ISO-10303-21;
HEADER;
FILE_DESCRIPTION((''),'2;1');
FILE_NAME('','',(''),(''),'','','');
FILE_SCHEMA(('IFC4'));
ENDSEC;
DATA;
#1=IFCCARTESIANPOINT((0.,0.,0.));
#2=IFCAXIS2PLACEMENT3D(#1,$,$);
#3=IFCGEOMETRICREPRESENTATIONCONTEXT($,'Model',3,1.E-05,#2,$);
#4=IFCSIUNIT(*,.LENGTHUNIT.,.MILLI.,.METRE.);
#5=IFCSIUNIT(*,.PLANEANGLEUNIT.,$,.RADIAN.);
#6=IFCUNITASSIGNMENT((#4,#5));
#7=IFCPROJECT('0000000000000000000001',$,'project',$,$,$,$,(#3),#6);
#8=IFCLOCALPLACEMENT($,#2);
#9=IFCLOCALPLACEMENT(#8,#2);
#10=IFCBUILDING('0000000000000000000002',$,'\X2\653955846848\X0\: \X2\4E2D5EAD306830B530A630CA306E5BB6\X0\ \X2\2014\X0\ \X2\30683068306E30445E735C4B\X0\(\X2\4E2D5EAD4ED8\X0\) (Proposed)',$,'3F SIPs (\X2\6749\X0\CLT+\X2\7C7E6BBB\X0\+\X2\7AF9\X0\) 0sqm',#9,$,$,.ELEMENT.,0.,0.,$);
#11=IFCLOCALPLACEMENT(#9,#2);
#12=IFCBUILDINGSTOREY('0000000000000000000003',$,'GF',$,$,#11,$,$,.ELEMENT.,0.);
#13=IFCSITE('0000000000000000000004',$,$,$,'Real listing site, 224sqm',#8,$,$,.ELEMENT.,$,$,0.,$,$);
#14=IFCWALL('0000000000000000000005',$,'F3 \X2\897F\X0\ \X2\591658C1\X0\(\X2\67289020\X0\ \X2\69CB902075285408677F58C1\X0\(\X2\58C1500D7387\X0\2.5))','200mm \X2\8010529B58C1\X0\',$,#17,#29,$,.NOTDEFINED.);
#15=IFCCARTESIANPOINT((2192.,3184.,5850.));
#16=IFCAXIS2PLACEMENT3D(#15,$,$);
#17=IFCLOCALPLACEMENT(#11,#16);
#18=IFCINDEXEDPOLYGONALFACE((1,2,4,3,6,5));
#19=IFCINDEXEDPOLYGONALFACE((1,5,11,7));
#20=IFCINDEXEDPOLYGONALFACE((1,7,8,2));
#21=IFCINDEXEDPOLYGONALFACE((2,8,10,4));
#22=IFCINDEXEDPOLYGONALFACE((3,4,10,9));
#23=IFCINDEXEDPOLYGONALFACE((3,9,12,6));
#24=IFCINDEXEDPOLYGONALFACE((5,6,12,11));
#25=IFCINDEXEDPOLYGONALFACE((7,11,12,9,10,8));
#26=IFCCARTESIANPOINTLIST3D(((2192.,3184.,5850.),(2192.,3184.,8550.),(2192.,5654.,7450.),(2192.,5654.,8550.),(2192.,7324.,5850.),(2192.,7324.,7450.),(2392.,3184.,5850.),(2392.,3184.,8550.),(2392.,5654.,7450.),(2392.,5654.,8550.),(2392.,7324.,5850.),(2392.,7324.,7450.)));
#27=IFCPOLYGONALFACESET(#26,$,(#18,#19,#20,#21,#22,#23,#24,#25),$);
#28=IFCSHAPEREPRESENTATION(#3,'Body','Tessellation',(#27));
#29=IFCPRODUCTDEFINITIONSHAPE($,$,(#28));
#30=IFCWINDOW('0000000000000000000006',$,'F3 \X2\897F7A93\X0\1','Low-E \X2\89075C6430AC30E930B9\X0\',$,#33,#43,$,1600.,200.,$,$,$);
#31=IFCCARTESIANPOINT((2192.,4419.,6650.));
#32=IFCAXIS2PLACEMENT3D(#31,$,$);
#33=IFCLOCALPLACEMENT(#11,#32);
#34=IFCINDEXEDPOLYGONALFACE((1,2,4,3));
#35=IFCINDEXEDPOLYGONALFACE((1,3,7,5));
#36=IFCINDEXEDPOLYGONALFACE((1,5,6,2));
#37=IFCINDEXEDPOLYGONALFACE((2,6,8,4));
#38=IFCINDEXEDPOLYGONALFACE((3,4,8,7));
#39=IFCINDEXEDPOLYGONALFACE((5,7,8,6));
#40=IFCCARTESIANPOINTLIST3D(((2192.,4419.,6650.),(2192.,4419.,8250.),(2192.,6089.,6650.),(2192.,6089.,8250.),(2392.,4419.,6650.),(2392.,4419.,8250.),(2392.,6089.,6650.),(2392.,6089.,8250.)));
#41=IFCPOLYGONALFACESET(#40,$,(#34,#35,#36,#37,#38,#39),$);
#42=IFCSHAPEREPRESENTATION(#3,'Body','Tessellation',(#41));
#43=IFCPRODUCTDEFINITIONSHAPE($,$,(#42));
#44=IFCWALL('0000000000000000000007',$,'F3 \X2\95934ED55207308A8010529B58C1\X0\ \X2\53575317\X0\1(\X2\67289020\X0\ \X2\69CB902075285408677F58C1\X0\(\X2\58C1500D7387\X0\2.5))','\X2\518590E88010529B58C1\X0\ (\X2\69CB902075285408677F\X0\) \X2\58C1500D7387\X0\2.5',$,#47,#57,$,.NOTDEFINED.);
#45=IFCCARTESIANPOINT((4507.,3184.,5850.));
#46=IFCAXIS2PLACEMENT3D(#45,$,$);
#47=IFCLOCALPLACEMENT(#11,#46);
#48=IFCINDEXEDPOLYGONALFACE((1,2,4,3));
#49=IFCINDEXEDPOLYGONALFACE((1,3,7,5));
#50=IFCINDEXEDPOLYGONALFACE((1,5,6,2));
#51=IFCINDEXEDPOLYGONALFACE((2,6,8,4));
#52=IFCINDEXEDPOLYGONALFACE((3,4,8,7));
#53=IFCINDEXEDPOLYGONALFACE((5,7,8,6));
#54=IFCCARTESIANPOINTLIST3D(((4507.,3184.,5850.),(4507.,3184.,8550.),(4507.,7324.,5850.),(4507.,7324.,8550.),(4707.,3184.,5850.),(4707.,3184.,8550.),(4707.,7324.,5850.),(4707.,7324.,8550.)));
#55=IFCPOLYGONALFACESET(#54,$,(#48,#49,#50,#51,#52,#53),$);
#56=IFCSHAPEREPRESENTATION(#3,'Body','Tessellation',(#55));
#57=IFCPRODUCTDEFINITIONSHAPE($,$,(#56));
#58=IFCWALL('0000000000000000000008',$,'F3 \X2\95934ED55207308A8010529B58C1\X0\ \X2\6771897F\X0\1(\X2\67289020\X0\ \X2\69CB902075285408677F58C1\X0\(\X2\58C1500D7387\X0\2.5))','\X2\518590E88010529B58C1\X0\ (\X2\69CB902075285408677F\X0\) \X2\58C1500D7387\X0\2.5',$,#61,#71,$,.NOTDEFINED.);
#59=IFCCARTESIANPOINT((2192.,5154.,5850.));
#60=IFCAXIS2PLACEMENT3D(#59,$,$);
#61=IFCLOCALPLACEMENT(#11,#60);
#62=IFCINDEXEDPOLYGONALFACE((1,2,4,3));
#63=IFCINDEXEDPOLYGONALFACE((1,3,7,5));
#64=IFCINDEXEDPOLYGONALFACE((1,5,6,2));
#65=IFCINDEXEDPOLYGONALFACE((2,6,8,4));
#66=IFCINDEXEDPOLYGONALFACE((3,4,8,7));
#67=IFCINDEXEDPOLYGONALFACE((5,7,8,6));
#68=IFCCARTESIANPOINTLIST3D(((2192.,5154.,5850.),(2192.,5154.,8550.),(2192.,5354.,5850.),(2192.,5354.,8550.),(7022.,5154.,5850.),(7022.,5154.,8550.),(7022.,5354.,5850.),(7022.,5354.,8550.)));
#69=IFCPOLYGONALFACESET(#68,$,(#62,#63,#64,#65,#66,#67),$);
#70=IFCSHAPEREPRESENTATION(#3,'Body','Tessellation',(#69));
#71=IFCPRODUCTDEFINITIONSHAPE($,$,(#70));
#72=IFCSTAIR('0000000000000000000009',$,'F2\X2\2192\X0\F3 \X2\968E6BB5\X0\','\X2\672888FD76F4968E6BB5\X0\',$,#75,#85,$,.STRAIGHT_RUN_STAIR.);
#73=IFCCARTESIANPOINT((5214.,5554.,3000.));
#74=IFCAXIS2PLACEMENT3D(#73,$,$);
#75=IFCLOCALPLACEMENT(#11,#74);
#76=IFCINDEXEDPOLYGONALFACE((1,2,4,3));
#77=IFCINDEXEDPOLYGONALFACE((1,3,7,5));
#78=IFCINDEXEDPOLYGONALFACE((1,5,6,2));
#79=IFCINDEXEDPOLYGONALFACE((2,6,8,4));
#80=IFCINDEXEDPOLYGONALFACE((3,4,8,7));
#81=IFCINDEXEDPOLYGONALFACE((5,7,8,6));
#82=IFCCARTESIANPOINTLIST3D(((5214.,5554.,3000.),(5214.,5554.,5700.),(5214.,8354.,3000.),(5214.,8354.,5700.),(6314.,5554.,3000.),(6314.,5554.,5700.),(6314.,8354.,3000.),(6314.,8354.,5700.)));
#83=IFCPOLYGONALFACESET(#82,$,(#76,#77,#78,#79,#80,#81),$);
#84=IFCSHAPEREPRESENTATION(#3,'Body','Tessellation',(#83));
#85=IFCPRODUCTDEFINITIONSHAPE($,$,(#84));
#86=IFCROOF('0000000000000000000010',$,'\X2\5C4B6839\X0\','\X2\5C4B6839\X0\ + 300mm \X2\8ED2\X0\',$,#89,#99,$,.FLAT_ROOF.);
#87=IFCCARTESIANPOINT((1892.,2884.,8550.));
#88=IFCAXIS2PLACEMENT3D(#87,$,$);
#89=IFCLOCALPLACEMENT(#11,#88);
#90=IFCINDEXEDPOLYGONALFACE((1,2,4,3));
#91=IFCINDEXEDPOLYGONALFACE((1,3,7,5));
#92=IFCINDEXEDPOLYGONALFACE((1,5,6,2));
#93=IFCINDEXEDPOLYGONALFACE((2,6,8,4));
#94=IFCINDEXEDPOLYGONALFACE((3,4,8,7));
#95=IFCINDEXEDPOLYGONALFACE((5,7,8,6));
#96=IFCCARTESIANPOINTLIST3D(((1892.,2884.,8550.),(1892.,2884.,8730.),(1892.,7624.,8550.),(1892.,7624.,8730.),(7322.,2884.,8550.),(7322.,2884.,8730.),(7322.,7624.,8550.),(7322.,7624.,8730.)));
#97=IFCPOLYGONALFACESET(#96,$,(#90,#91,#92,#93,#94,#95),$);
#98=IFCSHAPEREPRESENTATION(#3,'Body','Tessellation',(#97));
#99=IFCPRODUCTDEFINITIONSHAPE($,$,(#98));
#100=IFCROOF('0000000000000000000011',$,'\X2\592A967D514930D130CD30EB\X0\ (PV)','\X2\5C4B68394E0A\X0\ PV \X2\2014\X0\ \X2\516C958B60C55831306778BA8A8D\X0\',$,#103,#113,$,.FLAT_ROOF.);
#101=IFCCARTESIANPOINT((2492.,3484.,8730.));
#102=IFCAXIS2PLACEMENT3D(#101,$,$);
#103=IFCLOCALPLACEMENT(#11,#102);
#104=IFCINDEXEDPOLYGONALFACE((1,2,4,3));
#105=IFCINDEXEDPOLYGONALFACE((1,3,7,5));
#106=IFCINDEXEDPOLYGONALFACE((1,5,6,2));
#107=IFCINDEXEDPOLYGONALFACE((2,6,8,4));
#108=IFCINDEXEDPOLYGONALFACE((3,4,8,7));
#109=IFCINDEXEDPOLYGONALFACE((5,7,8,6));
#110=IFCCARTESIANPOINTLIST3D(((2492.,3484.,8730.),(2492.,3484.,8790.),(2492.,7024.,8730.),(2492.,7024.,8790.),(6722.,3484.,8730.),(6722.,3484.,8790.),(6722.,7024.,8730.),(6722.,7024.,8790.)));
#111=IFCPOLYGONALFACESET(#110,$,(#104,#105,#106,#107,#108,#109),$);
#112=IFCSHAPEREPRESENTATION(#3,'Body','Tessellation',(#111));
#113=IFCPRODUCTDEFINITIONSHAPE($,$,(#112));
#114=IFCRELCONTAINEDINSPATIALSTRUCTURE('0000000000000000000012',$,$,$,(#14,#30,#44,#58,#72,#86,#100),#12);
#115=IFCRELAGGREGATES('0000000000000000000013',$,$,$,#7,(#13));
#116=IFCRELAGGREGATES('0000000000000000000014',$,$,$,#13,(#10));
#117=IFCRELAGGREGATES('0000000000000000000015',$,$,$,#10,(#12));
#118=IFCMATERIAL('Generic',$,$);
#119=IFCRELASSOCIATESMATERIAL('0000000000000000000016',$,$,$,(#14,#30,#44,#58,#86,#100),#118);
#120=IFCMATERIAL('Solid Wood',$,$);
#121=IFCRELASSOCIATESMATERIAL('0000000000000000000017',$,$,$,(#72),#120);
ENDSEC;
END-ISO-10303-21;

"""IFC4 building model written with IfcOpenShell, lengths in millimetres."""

from ifc_helpers import new_model, si_unit, frame, frame_2d, origin, place, context, project, spatial, rectangle, extrude, material, element, fill, save


model = new_model("IFC4")

# Units and contexts
model_context = context("Model", 3, precision=1e-05, world=origin())
ifc_project = project(units=[si_unit("LENGTHUNIT", "METRE", prefix="MILLI"), si_unit("PLANEANGLEUNIT", "RADIAN")], contexts=[model_context])

# Site, building, storey
site_placement = place(None, origin())
site = spatial("IfcSite", under=ifc_project, at=site_placement, ObjectType="Real listing site, 224sqm", CompositionType="ELEMENT", RefElevation=0.0)
building_placement = place(site_placement, origin())
building = spatial("IfcBuilding", under=site, at=building_placement, Name="改善案: 中庭とサウナの家 — ととのい平屋(中庭付) (Proposed)", ObjectType="3F SIPs (杉CLT+籾殻+竹) 0sqm", CompositionType="ELEMENT", ElevationOfRefHeight=0.0, ElevationOfTerrain=0.0)
storey_placement = place(building_placement, origin())
storey = spatial("IfcBuildingStorey", under=building, at=storey_placement, Name="GF", CompositionType="ELEMENT", Elevation=0.0)

# Shared definitions
ifc_material_1 = material(Name="Generic")

# Wall, opening, window
wall_1_placement = place(storey_placement, frame((2192.0, 3184.0, 5850.0)))
wall_1 = element("IfcWall", 1, at=wall_1_placement, inside=storey, material=ifc_material_1, Name="F3 西 外壁(木造 構造用合板壁(壁倍率2.5))", Description="200mm 耐力壁", PredefinedType="NOTDEFINED", context=model_context, shape_type="SweptSolid", body=[
    extrude(rectangle(XDim=200.0, YDim=4140.0, at=frame_2d((100.0, 2070.0))), frame((2192.0, 3184.0, 5850.0)), (0.0, 0.0, 1.0), 2700.0),
])
opening_1_placement = place(storey_placement, frame((2192.0, 4419.0, 6650.0)))
opening_1 = element("IfcOpeningElement", 2, at=opening_1_placement, cuts=wall_1, PredefinedType="NOTDEFINED", context=model_context, shape_type="SweptSolid", body=[
    extrude(rectangle(XDim=200.0, YDim=1670.0, at=frame_2d((100.0, 835.0))), frame((2192.0, 4419.0, 6650.0)), (0.0, 0.0, 1.0), 1600.0),
])
window_1_placement = place(storey_placement, frame((2192.0, 4419.0, 6650.0)))
window_1 = element("IfcWindow", 3, at=window_1_placement, inside=storey, material=ifc_material_1, Name="F3 西窓1", Description="Low-E 複層ガラス", OverallHeight=1600.0, OverallWidth=200.0, context=model_context, shape_type="SweptSolid", body=[
    extrude(rectangle(XDim=200.0, YDim=1670.0, at=frame_2d((100.0, 835.0))), frame((2192.0, 4419.0, 6650.0)), (0.0, 0.0, 1.0), 1600.0),
])
fill(opening_1, window_1)

# Walls
wall_2_placement = place(storey_placement, frame((4507.0, 3184.0, 5850.0)))
element("IfcWall", 4, at=wall_2_placement, inside=storey, material=ifc_material_1, Name="F3 間仕切り耐力壁 南北1(木造 構造用合板壁(壁倍率2.5))", Description="内部耐力壁 (構造用合板) 壁倍率2.5", PredefinedType="NOTDEFINED", context=model_context, shape_type="SweptSolid", body=[
    extrude(rectangle(XDim=200.0, YDim=4140.0, at=frame_2d((100.0, 2070.0))), frame((4507.0, 3184.0, 5850.0)), (0.0, 0.0, 1.0), 2700.0),
])
wall_3_placement = place(storey_placement, frame((2192.0, 5154.0, 5850.0)))
element("IfcWall", 5, at=wall_3_placement, inside=storey, material=ifc_material_1, Name="F3 間仕切り耐力壁 東西1(木造 構造用合板壁(壁倍率2.5))", Description="内部耐力壁 (構造用合板) 壁倍率2.5", PredefinedType="NOTDEFINED", context=model_context, shape_type="SweptSolid", body=[
    extrude(rectangle(XDim=4830.0, YDim=200.0, at=frame_2d((2415.0, 100.0))), frame((2192.0, 5154.0, 5850.0)), (0.0, 0.0, 1.0), 2700.0),
])

# Stair
ifc_material_2 = material(Name="Solid Wood")
stair_placement = place(storey_placement, frame((5214.0, 5554.0, 3000.0)))
element("IfcStair", 6, at=stair_placement, inside=storey, material=ifc_material_2, Name="F2→F3 階段", Description="木製直階段", PredefinedType="STRAIGHT_RUN_STAIR", context=model_context, shape_type="SweptSolid", body=[
    extrude(rectangle(XDim=1100.0, YDim=2800.0, at=frame_2d((550.0, 1400.0))), frame((5214.0, 5554.0, 3000.0)), (0.0, 0.0, 1.0), 2700.0),
])

# Roofs
roof_1_placement = place(storey_placement, frame((1892.0, 2884.0, 8550.0)))
element("IfcRoof", 7, at=roof_1_placement, inside=storey, material=ifc_material_1, Name="屋根", Description="屋根 + 300mm 軒", PredefinedType="FLAT_ROOF", context=model_context, shape_type="SweptSolid", body=[
    extrude(rectangle(XDim=5430.0, YDim=4740.0, at=frame_2d((2715.0, 2370.0))), frame((1892.0, 2884.0, 8550.0)), (0.0, 0.0, 1.0), 180.0),
])
roof_2_placement = place(storey_placement, frame((2492.0, 3484.0, 8730.0)))
element("IfcRoof", 8, at=roof_2_placement, inside=storey, material=ifc_material_1, Name="太陽光パネル (PV)", Description="屋根上 PV — 公開情報で確認", PredefinedType="FLAT_ROOF", context=model_context, shape_type="SweptSolid", body=[
    extrude(rectangle(XDim=4230.0, YDim=3540.0, at=frame_2d((2115.0, 1770.0))), frame((2492.0, 3484.0, 8730.0)), (0.0, 0.0, 1.0), 60.0),
])

save(model, "model.ifc")
